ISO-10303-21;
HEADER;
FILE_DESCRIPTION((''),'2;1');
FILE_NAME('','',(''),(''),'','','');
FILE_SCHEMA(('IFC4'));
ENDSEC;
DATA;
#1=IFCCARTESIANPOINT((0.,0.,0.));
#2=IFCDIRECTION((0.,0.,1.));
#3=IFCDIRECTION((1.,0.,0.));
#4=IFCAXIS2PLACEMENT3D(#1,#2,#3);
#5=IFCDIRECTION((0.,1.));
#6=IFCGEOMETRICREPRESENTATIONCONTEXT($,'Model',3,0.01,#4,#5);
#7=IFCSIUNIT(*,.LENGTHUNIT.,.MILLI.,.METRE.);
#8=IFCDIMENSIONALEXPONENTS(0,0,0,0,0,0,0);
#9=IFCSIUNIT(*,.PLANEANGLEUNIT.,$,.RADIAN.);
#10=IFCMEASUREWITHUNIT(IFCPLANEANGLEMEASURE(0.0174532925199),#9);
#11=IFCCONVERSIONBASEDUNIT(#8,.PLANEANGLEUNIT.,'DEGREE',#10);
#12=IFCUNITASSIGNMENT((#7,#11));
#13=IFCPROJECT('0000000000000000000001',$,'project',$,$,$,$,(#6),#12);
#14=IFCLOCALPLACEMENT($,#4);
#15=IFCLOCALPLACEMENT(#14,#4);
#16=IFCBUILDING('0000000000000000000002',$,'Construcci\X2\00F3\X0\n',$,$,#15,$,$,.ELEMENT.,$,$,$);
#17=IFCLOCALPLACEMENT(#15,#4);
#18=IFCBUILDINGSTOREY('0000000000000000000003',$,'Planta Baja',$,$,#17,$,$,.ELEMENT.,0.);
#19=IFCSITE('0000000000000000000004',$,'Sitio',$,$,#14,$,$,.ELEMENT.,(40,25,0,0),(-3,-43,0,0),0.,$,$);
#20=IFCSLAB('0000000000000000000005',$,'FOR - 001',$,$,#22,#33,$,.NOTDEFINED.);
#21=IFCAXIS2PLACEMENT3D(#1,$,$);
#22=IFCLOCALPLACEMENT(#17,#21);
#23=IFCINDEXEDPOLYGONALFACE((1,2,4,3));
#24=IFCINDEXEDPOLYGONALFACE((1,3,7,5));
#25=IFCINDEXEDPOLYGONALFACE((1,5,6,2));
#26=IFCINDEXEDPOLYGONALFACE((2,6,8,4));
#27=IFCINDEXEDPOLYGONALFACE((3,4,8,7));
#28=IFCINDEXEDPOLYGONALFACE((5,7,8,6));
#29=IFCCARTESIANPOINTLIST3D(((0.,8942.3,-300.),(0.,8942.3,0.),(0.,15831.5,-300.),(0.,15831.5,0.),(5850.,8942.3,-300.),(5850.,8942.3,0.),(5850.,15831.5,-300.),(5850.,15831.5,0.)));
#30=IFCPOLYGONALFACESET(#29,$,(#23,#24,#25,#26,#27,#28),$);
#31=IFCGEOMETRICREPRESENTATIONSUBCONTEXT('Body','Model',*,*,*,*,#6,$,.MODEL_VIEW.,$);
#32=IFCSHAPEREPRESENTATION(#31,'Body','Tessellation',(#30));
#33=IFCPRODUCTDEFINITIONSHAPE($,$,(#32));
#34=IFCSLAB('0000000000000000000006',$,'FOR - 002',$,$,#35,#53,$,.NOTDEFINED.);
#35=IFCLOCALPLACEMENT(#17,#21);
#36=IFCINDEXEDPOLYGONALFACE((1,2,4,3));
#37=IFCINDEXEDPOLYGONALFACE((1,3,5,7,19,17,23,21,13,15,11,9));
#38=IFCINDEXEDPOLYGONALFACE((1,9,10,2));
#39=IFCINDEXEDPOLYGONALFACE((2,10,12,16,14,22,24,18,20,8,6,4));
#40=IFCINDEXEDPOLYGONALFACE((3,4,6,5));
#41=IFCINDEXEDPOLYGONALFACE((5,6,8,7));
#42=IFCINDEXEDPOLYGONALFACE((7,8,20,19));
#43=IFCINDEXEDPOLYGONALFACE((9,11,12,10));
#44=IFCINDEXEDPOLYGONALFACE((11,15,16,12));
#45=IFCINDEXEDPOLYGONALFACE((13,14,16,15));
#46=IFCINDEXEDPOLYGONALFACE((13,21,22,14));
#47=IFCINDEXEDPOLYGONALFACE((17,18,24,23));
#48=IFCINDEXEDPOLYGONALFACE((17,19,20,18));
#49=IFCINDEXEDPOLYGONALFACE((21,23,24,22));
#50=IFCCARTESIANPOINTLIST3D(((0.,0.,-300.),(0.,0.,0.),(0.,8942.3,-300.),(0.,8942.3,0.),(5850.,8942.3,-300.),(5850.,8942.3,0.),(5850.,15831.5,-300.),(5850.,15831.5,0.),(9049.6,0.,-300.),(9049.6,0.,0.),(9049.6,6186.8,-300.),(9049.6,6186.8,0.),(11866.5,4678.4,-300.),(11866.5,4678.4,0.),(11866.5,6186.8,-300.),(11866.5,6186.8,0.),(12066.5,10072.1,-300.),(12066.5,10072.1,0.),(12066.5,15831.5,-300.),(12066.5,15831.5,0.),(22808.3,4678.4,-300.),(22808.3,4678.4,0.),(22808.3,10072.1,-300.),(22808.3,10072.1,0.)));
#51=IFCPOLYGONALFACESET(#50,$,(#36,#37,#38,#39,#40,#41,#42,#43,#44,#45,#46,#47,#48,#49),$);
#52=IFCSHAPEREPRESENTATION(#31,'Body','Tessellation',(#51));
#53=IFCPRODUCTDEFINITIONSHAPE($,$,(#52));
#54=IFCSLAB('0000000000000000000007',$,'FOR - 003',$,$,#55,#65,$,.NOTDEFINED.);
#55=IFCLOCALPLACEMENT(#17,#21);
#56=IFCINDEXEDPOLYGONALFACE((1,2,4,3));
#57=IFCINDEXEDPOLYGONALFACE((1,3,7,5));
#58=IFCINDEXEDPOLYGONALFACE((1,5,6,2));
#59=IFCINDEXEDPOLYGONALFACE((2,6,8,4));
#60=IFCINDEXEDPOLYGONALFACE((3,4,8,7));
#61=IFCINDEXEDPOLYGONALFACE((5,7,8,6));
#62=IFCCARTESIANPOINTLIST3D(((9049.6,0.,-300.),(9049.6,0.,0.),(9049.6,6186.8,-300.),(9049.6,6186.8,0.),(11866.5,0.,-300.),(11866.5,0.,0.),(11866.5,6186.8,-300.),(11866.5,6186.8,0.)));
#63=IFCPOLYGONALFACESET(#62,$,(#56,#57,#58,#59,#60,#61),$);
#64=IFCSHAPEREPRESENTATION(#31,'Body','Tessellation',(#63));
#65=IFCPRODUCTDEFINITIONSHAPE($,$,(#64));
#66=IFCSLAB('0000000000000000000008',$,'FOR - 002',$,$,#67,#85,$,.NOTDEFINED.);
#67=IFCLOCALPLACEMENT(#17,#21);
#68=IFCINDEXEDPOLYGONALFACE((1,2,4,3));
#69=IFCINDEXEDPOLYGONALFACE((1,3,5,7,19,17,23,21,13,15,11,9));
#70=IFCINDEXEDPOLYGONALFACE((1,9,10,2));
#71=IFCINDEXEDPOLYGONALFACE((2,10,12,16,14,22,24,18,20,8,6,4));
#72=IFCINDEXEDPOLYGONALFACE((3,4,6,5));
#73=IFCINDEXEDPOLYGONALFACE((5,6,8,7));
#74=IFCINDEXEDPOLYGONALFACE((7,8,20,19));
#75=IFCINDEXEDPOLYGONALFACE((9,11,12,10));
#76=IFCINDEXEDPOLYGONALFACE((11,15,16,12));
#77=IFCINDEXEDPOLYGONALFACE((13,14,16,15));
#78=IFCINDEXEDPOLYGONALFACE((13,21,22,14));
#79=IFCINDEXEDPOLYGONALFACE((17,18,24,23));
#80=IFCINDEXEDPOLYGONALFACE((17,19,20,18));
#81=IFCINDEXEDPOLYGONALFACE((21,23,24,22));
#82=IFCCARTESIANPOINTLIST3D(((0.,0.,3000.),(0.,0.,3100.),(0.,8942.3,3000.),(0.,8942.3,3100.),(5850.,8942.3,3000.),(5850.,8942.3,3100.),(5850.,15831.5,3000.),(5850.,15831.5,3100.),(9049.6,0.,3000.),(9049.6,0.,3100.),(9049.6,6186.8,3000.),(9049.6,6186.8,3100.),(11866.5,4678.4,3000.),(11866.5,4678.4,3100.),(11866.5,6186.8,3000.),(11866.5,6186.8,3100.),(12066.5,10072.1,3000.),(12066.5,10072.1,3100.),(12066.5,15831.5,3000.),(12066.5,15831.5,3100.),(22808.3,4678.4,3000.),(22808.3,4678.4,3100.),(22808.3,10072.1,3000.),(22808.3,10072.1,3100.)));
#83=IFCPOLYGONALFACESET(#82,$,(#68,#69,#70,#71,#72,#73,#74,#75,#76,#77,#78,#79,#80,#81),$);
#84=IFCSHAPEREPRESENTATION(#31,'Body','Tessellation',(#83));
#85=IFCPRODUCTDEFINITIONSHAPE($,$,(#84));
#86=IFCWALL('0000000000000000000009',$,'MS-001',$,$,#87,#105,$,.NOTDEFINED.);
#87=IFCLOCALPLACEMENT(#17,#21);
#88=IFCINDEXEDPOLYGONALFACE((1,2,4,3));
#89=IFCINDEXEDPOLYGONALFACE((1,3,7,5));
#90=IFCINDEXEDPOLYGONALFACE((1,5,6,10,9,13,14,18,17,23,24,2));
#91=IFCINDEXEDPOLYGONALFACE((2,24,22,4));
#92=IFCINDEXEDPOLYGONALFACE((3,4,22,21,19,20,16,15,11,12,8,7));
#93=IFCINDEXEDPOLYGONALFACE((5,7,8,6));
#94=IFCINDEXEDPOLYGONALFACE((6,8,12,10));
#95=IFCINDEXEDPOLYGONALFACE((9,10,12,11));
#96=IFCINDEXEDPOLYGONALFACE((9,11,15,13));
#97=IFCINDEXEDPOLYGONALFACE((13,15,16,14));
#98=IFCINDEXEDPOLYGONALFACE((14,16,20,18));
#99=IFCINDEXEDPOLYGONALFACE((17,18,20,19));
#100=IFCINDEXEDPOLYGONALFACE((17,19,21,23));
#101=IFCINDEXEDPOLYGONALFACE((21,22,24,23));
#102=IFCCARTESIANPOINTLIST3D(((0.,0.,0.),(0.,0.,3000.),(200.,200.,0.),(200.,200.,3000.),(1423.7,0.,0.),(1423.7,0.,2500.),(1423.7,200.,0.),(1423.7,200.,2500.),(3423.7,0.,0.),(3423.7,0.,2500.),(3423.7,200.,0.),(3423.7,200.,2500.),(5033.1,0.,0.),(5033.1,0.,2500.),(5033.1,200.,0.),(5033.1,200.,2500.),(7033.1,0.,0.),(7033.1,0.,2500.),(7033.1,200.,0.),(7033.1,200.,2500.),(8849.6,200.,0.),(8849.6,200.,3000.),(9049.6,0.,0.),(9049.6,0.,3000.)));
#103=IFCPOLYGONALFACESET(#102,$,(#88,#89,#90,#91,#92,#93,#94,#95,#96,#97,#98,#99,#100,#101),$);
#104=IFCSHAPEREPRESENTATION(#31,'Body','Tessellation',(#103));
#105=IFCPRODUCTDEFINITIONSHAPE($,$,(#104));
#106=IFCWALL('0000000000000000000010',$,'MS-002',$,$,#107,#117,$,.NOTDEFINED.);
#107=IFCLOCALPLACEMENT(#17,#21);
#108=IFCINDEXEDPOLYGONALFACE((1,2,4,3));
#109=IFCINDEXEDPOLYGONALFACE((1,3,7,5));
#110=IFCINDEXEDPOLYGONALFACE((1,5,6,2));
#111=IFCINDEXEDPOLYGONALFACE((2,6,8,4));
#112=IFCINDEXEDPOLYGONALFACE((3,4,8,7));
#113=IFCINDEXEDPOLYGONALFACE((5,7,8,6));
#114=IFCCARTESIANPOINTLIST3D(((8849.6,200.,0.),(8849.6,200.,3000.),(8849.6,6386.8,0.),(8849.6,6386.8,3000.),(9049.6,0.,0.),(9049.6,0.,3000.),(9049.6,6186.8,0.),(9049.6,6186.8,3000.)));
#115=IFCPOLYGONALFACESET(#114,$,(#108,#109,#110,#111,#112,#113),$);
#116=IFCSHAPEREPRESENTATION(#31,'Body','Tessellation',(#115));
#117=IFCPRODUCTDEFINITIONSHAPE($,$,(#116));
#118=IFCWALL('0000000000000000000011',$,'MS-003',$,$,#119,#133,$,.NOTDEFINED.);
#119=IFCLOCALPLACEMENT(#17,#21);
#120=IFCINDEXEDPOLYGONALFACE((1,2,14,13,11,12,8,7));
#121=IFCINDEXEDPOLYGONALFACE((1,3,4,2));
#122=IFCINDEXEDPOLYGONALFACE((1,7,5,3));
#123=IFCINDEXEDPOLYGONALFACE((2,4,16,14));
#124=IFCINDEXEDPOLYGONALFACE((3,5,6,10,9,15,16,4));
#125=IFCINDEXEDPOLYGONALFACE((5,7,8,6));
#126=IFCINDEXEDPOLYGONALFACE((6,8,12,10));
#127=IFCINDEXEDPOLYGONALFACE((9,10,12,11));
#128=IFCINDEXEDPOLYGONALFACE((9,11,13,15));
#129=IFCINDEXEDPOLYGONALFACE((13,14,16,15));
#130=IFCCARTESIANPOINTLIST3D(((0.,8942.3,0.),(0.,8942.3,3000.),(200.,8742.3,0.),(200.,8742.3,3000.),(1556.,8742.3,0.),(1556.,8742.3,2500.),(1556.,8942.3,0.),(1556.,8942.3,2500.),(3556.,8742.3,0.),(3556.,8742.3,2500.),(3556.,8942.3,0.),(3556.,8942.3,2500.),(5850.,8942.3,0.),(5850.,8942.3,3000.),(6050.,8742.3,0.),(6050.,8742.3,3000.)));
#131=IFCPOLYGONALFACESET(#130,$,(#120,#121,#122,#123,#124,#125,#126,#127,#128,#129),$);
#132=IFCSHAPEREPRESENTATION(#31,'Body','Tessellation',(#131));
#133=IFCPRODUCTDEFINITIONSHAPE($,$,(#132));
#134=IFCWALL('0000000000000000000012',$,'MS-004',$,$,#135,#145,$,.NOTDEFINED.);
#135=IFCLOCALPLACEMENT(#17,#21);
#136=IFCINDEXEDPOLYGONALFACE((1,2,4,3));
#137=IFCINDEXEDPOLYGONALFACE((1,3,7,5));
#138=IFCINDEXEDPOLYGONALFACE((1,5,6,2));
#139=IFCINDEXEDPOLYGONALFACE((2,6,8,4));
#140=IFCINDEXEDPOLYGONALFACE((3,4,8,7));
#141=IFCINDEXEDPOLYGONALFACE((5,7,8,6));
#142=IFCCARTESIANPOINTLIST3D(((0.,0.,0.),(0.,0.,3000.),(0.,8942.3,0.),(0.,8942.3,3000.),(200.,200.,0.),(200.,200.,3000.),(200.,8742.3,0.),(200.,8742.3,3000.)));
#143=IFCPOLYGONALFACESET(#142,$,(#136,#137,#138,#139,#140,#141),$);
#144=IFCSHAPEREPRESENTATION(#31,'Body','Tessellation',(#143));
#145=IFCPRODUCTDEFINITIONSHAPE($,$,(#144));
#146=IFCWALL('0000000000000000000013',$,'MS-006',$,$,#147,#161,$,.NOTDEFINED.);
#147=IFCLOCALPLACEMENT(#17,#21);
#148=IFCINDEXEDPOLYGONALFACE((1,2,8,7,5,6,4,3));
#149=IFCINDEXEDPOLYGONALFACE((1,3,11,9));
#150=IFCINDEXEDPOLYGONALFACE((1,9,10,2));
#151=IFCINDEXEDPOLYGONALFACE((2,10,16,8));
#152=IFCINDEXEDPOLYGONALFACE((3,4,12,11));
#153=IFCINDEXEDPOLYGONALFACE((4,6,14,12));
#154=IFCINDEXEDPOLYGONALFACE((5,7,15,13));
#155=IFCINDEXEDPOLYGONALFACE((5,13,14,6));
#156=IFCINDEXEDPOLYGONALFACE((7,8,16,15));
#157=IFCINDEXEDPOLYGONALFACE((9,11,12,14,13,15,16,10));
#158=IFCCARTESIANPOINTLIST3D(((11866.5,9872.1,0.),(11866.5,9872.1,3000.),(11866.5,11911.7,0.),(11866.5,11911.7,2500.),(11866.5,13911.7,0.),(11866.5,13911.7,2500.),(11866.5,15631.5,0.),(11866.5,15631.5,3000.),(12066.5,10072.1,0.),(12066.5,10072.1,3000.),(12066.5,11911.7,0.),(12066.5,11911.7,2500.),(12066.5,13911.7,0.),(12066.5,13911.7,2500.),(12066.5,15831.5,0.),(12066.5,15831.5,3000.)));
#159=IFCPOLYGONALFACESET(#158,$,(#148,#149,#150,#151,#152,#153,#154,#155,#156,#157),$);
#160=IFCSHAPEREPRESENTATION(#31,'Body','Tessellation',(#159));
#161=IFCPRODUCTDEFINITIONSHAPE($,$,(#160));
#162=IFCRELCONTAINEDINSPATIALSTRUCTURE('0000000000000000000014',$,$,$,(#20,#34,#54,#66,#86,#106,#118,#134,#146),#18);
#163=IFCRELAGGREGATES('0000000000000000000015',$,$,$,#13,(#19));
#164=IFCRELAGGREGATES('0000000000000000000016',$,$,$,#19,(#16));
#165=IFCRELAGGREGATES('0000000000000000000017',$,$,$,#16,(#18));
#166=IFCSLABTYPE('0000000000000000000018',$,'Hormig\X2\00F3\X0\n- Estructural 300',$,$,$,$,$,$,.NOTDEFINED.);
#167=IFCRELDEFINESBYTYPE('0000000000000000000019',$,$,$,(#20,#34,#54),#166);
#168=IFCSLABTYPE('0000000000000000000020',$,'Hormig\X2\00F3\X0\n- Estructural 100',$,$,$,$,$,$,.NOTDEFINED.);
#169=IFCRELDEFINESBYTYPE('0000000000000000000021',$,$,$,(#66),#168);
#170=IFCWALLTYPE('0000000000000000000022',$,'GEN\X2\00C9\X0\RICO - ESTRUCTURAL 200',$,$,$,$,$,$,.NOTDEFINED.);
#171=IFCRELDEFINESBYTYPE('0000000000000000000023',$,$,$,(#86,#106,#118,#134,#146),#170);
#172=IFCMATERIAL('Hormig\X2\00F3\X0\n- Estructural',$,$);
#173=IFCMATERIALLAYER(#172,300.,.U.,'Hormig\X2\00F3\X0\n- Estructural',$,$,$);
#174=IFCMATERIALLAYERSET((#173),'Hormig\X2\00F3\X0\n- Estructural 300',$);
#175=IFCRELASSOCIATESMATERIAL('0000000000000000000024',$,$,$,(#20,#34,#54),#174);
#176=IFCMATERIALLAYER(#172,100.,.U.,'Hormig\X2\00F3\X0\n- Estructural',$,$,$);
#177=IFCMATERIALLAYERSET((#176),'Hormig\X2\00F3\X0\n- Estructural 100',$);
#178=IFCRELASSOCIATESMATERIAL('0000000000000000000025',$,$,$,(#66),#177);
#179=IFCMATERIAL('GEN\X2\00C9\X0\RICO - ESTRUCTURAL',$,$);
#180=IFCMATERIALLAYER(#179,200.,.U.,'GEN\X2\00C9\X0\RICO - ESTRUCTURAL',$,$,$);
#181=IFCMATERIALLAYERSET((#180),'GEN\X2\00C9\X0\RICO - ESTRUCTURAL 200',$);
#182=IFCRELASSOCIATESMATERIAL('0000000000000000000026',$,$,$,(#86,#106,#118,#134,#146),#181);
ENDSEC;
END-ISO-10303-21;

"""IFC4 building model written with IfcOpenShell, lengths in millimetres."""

from ifc_helpers import new_model, entity, si_unit, converted_unit, direction, frame, origin_with_axes, origin_2d_with_axis, place, context, subcontext, project, spatial, line, indexed_curve, rectangle, outline, extrude, material, layer, layer_set, layer_usage, type_object, element, save


model = new_model("IFC4")

# Units and contexts
model_context = context("Model", 3, precision=0.01, world=origin_with_axes(), true_north=direction((0.0, 1.0)))
body_context = subcontext(model_context, "Body", "Model", "MODEL_VIEW")
ifc_project = project(units=[si_unit("LENGTHUNIT", "METRE", prefix="MILLI"), converted_unit("PLANEANGLEUNIT", "DEGREE", entity("IfcPlaneAngleMeasure", 0.0174532925199), si_unit("PLANEANGLEUNIT", "RADIAN"), dimensions=[0, 0, 0, 0, 0, 0, 0])], contexts=[model_context])

# Site, building, storey
site_placement = place(None, origin_with_axes())
site = spatial("IfcSite", under=ifc_project, at=site_placement, Name="Sitio", CompositionType="ELEMENT", RefLatitude=(40, 25, 0, 0), RefLongitude=(-3, -43, 0, 0), RefElevation=0.0)
building_placement = place(site_placement, origin_with_axes())
building = spatial("IfcBuilding", under=site, at=building_placement, Name="Construcción", CompositionType="ELEMENT")
storey_placement = place(building_placement, origin_with_axes())
storey = spatial("IfcBuildingStorey", under=building, at=storey_placement, Name="Planta Baja", CompositionType="ELEMENT", Elevation=0.0)

# Slabs
ifc_material_1 = material(Name="Hormigón- Estructural")
ifc_layer_1 = layer(ifc_material_1, 300.0, ventilated="UNKNOWN", Name="Hormigón- Estructural")
ifc_layer_set_1 = layer_set([ifc_layer_1], Name="Hormigón- Estructural 300")
ifc_layer_usage_1 = layer_usage(ifc_layer_set_1, "AXIS3", "NEGATIVE", 300.0)
slab_type_1 = type_object("IfcSlabType", Name="Hormigón- Estructural 300", PredefinedType="NOTDEFINED")
slab_1_placement = place(storey_placement, frame((0.0, 8942.3, 0.0), z_axis=(0.0, 0.0, 1.0), x_axis=(1.0, 0.0, 0.0)))
element("IfcSlab", 1, at=slab_1_placement, inside=storey, type_object=slab_type_1, material=ifc_layer_usage_1, Name="FOR - 001", PredefinedType="NOTDEFINED", context=body_context, shape_type="SweptSolid", body=[
    extrude(outline(indexed_curve([(0.0, 0.0), (5850.0, 0.0), (5850.0, 6889.2), (0.0, 6889.2)], segments=[line(1, 2, 3, 4, 1)])), frame((0.0, 0.0, -300.0), z_axis=(0.0, 0.0, 1.0), x_axis=(1.0, 0.0, 0.0)), (0.0, 0.0, 1.0), 300.0),
])
ifc_layer_usage_2 = layer_usage(ifc_layer_set_1, "AXIS3", "NEGATIVE", 300.0)
slab_2_placement = place(storey_placement, frame((5850.0, 8942.3, 0.0), z_axis=(0.0, 0.0, 1.0), x_axis=(1.0, 0.0, 0.0)))
element("IfcSlab", 2, at=slab_2_placement, inside=storey, type_object=slab_type_1, material=ifc_layer_usage_2, Name="FOR - 002", PredefinedType="NOTDEFINED", context=body_context, shape_type="SweptSolid", body=[
    extrude(outline(indexed_curve([(0.0, 0.0), (-5850.0, 0.0), (-5850.0, -8942.3), (3199.7, -8942.3), (3199.7, -2755.5), (6016.5, -2755.5), (6016.5, -4264.0), (16958.3, -4264.0), (16958.3, 1129.8), (6216.5, 1129.8), (6216.5, 6889.2), (0.0, 6889.2)], segments=[line(1, 2, 3, 4, 5, 6, 7, 8, 9, 10, 11, 12, 1)])), frame((0.0, 0.0, -300.0), z_axis=(0.0, 0.0, 1.0), x_axis=(1.0, 0.0, 0.0)), (0.0, 0.0, 1.0), 300.0),
])
ifc_layer_usage_3 = layer_usage(ifc_layer_set_1, "AXIS3", "NEGATIVE", 300.0)
slab_3_placement = place(storey_placement, frame((9049.6, 0.0, 0.0), z_axis=(0.0, 0.0, 1.0), x_axis=(1.0, 0.0, 0.0)))
element("IfcSlab", 3, at=slab_3_placement, inside=storey, type_object=slab_type_1, material=ifc_layer_usage_3, Name="FOR - 003", PredefinedType="NOTDEFINED", context=body_context, shape_type="SweptSolid", body=[
    extrude(outline(indexed_curve([(0.0, 0.0), (2816.8, 0.0), (2816.8, 6186.8), (0.0, 6186.8)], segments=[line(1, 2, 3, 4, 1)])), frame((0.0, 0.0, -300.0), z_axis=(0.0, 0.0, 1.0), x_axis=(1.0, 0.0, 0.0)), (0.0, 0.0, 1.0), 300.0),
])
ifc_layer_2 = layer(ifc_material_1, 100.0, ventilated="UNKNOWN", Name="Hormigón- Estructural")
ifc_layer_set_2 = layer_set([ifc_layer_2], Name="Hormigón- Estructural 100")
ifc_layer_usage_4 = layer_usage(ifc_layer_set_2, "AXIS3", "NEGATIVE", 100.0)
slab_type_2 = type_object("IfcSlabType", Name="Hormigón- Estructural 100", PredefinedType="NOTDEFINED")
slab_4_placement = place(storey_placement, frame((5850.0, 8942.3, 3100.0), z_axis=(0.0, 0.0, 1.0), x_axis=(1.0, 0.0, 0.0)))
element("IfcSlab", 4, at=slab_4_placement, inside=storey, type_object=slab_type_2, material=ifc_layer_usage_4, Name="FOR - 002", PredefinedType="NOTDEFINED", context=body_context, shape_type="SweptSolid", body=[
    extrude(outline(indexed_curve([(0.0, 0.0), (-5850.0, 0.0), (-5850.0, -8942.3), (3199.7, -8942.3), (3199.7, -2755.5), (6016.5, -2755.5), (6016.5, -4264.0), (16958.3, -4264.0), (16958.3, 1129.8), (6216.5, 1129.8), (6216.5, 6889.2), (0.0, 6889.2)], segments=[line(1, 2, 3, 4, 5, 6, 7, 8, 9, 10, 11, 12, 1)])), frame((0.0, 0.0, -100.0), z_axis=(0.0, 0.0, 1.0), x_axis=(1.0, 0.0, 0.0)), (0.0, 0.0, 1.0), 100.0),
])

# Wall, openings
ifc_material_2 = material(Name="GENÉRICO - ESTRUCTURAL")
ifc_layer_3 = layer(ifc_material_2, 200.0, ventilated="UNKNOWN", Name="GENÉRICO - ESTRUCTURAL")
ifc_layer_set_3 = layer_set([ifc_layer_3], Name="GENÉRICO - ESTRUCTURAL 200")
ifc_layer_usage_5 = layer_usage(ifc_layer_set_3, "AXIS2", "POSITIVE", 0.0)
wall_type = type_object("IfcWallType", Name="GENÉRICO - ESTRUCTURAL 200", PredefinedType="NOTDEFINED")
wall_1_placement = place(storey_placement, origin_with_axes())
wall_1 = element("IfcWall", 5, at=wall_1_placement, inside=storey, type_object=wall_type, material=ifc_layer_usage_5, Name="MS-001", PredefinedType="NOTDEFINED", context=body_context, shape_type="SweptSolid", body=[
    extrude(outline(indexed_curve([(0.0, 0.0), (9049.6, 0.0), (8849.6, 200.0), (200.0, 200.0)], segments=[line(1, 2, 3, 4, 1)])), origin_with_axes(), (0.0, 0.0, 1.0), 3000.0),
])
opening_1_placement = place(wall_1_placement, frame((6033.1, 0.0, 0.0), z_axis=(0.0, 0.0, 1.0), x_axis=(1.0, 0.0, 0.0)))
element("IfcOpeningElement", 6, at=opening_1_placement, cuts=wall_1, context=body_context, shape_type="SweptSolid", body=[
    extrude(rectangle(XDim=2000.0, YDim=2500.0, at=origin_2d_with_axis()), frame((0.0, 200.0, 1250.0), z_axis=(0.0, 1.0, 0.0), x_axis=(-1.0, 0.0, 0.0)), (0.0, 0.0, -1.0), 600.0),
])
opening_2_placement = place(wall_1_placement, frame((2423.7, 0.0, 0.0), z_axis=(0.0, 0.0, 1.0), x_axis=(1.0, 0.0, 0.0)))
element("IfcOpeningElement", 7, at=opening_2_placement, cuts=wall_1, context=body_context, shape_type="SweptSolid", body=[
    extrude(rectangle(XDim=2000.0, YDim=2500.0, at=origin_2d_with_axis()), frame((0.0, 200.0, 1250.0), z_axis=(0.0, 1.0, 0.0), x_axis=(-1.0, 0.0, 0.0)), (0.0, 0.0, -1.0), 600.0),
])

# Wall
ifc_layer_usage_6 = layer_usage(ifc_layer_set_3, "AXIS2", "POSITIVE", 0.0)
wall_2_placement = place(storey_placement, frame((9049.6, 0.0, 0.0), z_axis=(0.0, 0.0, 1.0), x_axis=(0.0, 1.0, 0.0)))
element("IfcWall", 8, at=wall_2_placement, inside=storey, type_object=wall_type, material=ifc_layer_usage_6, Name="MS-002", PredefinedType="NOTDEFINED", context=body_context, shape_type="SweptSolid", body=[
    extrude(outline(indexed_curve([(0.0, 0.0), (6186.8, 0.0), (6386.8, 200.0), (200.0, 200.0)], segments=[line(1, 2, 3, 4, 1)])), origin_with_axes(), (0.0, 0.0, 1.0), 3000.0),
])

# Wall, opening
ifc_layer_usage_7 = layer_usage(ifc_layer_set_3, "AXIS2", "POSITIVE", 0.0)
wall_3_placement = place(storey_placement, frame((5850.0, 8942.3, 0.0), z_axis=(0.0, 0.0, 1.0), x_axis=(-1.0, 0.0, 0.0)))
wall_3 = element("IfcWall", 9, at=wall_3_placement, inside=storey, type_object=wall_type, material=ifc_layer_usage_7, Name="MS-003", PredefinedType="NOTDEFINED", context=body_context, shape_type="SweptSolid", body=[
    extrude(outline(indexed_curve([(0.0, 0.0), (5850.0, 0.0), (5650.0, 200.0), (-200.0, 200.0)], segments=[line(1, 2, 3, 4, 1)])), origin_with_axes(), (0.0, 0.0, 1.0), 3000.0),
])
opening_3_placement = place(wall_3_placement, frame((3294.0, 0.0, 0.0), z_axis=(0.0, 0.0, 1.0), x_axis=(1.0, 0.0, 0.0)))
element("IfcOpeningElement", 10, at=opening_3_placement, cuts=wall_3, context=body_context, shape_type="SweptSolid", body=[
    extrude(rectangle(XDim=2000.0, YDim=2500.0, at=origin_2d_with_axis()), frame((0.0, -200.0, 1250.0), z_axis=(0.0, -1.0, 0.0), x_axis=(-1.0, 0.0, 0.0)), (0.0, 0.0, -1.0), 600.0),
])

# Wall
ifc_layer_usage_8 = layer_usage(ifc_layer_set_3, "AXIS2", "POSITIVE", 0.0)
wall_4_placement = place(storey_placement, frame((0.0, 8942.3, 0.0), z_axis=(0.0, 0.0, 1.0), x_axis=(0.0, -1.0, 0.0)))
element("IfcWall", 11, at=wall_4_placement, inside=storey, type_object=wall_type, material=ifc_layer_usage_8, Name="MS-004", PredefinedType="NOTDEFINED", context=body_context, shape_type="SweptSolid", body=[
    extrude(outline(indexed_curve([(0.0, 0.0), (8942.3, 0.0), (8742.3, 200.0), (200.0, 200.0)], segments=[line(1, 2, 3, 4, 1)])), origin_with_axes(), (0.0, 0.0, 1.0), 3000.0),
])

# Wall, opening
ifc_layer_usage_9 = layer_usage(ifc_layer_set_3, "AXIS2", "POSITIVE", 0.0)
wall_5_placement = place(storey_placement, frame((12066.5, 10072.1, 0.0), z_axis=(0.0, 0.0, 1.0), x_axis=(0.0, 1.0, 0.0)))
wall_5 = element("IfcWall", 12, at=wall_5_placement, inside=storey, type_object=wall_type, material=ifc_layer_usage_9, Name="MS-006", PredefinedType="NOTDEFINED", context=body_context, shape_type="SweptSolid", body=[
    extrude(outline(indexed_curve([(0.0, 0.0), (5759.4, 0.0), (5559.4, 200.0), (-200.0, 200.0)], segments=[line(1, 2, 3, 4, 1)])), origin_with_axes(), (0.0, 0.0, 1.0), 3000.0),
])
opening_4_placement = place(wall_5_placement, frame((2839.6, 0.0, 0.0), z_axis=(0.0, 0.0, 1.0), x_axis=(1.0, 0.0, 0.0)))
element("IfcOpeningElement", 13, at=opening_4_placement, cuts=wall_5, context=body_context, shape_type="SweptSolid", body=[
    extrude(rectangle(XDim=2000.0, YDim=2500.0, at=origin_2d_with_axis()), frame((0.0, 200.0, 1250.0), z_axis=(0.0, 1.0, 0.0), x_axis=(1.0, 0.0, 0.0)), (0.0, 0.0, -1.0), 600.0),
])

save(model, "model.ifc")
